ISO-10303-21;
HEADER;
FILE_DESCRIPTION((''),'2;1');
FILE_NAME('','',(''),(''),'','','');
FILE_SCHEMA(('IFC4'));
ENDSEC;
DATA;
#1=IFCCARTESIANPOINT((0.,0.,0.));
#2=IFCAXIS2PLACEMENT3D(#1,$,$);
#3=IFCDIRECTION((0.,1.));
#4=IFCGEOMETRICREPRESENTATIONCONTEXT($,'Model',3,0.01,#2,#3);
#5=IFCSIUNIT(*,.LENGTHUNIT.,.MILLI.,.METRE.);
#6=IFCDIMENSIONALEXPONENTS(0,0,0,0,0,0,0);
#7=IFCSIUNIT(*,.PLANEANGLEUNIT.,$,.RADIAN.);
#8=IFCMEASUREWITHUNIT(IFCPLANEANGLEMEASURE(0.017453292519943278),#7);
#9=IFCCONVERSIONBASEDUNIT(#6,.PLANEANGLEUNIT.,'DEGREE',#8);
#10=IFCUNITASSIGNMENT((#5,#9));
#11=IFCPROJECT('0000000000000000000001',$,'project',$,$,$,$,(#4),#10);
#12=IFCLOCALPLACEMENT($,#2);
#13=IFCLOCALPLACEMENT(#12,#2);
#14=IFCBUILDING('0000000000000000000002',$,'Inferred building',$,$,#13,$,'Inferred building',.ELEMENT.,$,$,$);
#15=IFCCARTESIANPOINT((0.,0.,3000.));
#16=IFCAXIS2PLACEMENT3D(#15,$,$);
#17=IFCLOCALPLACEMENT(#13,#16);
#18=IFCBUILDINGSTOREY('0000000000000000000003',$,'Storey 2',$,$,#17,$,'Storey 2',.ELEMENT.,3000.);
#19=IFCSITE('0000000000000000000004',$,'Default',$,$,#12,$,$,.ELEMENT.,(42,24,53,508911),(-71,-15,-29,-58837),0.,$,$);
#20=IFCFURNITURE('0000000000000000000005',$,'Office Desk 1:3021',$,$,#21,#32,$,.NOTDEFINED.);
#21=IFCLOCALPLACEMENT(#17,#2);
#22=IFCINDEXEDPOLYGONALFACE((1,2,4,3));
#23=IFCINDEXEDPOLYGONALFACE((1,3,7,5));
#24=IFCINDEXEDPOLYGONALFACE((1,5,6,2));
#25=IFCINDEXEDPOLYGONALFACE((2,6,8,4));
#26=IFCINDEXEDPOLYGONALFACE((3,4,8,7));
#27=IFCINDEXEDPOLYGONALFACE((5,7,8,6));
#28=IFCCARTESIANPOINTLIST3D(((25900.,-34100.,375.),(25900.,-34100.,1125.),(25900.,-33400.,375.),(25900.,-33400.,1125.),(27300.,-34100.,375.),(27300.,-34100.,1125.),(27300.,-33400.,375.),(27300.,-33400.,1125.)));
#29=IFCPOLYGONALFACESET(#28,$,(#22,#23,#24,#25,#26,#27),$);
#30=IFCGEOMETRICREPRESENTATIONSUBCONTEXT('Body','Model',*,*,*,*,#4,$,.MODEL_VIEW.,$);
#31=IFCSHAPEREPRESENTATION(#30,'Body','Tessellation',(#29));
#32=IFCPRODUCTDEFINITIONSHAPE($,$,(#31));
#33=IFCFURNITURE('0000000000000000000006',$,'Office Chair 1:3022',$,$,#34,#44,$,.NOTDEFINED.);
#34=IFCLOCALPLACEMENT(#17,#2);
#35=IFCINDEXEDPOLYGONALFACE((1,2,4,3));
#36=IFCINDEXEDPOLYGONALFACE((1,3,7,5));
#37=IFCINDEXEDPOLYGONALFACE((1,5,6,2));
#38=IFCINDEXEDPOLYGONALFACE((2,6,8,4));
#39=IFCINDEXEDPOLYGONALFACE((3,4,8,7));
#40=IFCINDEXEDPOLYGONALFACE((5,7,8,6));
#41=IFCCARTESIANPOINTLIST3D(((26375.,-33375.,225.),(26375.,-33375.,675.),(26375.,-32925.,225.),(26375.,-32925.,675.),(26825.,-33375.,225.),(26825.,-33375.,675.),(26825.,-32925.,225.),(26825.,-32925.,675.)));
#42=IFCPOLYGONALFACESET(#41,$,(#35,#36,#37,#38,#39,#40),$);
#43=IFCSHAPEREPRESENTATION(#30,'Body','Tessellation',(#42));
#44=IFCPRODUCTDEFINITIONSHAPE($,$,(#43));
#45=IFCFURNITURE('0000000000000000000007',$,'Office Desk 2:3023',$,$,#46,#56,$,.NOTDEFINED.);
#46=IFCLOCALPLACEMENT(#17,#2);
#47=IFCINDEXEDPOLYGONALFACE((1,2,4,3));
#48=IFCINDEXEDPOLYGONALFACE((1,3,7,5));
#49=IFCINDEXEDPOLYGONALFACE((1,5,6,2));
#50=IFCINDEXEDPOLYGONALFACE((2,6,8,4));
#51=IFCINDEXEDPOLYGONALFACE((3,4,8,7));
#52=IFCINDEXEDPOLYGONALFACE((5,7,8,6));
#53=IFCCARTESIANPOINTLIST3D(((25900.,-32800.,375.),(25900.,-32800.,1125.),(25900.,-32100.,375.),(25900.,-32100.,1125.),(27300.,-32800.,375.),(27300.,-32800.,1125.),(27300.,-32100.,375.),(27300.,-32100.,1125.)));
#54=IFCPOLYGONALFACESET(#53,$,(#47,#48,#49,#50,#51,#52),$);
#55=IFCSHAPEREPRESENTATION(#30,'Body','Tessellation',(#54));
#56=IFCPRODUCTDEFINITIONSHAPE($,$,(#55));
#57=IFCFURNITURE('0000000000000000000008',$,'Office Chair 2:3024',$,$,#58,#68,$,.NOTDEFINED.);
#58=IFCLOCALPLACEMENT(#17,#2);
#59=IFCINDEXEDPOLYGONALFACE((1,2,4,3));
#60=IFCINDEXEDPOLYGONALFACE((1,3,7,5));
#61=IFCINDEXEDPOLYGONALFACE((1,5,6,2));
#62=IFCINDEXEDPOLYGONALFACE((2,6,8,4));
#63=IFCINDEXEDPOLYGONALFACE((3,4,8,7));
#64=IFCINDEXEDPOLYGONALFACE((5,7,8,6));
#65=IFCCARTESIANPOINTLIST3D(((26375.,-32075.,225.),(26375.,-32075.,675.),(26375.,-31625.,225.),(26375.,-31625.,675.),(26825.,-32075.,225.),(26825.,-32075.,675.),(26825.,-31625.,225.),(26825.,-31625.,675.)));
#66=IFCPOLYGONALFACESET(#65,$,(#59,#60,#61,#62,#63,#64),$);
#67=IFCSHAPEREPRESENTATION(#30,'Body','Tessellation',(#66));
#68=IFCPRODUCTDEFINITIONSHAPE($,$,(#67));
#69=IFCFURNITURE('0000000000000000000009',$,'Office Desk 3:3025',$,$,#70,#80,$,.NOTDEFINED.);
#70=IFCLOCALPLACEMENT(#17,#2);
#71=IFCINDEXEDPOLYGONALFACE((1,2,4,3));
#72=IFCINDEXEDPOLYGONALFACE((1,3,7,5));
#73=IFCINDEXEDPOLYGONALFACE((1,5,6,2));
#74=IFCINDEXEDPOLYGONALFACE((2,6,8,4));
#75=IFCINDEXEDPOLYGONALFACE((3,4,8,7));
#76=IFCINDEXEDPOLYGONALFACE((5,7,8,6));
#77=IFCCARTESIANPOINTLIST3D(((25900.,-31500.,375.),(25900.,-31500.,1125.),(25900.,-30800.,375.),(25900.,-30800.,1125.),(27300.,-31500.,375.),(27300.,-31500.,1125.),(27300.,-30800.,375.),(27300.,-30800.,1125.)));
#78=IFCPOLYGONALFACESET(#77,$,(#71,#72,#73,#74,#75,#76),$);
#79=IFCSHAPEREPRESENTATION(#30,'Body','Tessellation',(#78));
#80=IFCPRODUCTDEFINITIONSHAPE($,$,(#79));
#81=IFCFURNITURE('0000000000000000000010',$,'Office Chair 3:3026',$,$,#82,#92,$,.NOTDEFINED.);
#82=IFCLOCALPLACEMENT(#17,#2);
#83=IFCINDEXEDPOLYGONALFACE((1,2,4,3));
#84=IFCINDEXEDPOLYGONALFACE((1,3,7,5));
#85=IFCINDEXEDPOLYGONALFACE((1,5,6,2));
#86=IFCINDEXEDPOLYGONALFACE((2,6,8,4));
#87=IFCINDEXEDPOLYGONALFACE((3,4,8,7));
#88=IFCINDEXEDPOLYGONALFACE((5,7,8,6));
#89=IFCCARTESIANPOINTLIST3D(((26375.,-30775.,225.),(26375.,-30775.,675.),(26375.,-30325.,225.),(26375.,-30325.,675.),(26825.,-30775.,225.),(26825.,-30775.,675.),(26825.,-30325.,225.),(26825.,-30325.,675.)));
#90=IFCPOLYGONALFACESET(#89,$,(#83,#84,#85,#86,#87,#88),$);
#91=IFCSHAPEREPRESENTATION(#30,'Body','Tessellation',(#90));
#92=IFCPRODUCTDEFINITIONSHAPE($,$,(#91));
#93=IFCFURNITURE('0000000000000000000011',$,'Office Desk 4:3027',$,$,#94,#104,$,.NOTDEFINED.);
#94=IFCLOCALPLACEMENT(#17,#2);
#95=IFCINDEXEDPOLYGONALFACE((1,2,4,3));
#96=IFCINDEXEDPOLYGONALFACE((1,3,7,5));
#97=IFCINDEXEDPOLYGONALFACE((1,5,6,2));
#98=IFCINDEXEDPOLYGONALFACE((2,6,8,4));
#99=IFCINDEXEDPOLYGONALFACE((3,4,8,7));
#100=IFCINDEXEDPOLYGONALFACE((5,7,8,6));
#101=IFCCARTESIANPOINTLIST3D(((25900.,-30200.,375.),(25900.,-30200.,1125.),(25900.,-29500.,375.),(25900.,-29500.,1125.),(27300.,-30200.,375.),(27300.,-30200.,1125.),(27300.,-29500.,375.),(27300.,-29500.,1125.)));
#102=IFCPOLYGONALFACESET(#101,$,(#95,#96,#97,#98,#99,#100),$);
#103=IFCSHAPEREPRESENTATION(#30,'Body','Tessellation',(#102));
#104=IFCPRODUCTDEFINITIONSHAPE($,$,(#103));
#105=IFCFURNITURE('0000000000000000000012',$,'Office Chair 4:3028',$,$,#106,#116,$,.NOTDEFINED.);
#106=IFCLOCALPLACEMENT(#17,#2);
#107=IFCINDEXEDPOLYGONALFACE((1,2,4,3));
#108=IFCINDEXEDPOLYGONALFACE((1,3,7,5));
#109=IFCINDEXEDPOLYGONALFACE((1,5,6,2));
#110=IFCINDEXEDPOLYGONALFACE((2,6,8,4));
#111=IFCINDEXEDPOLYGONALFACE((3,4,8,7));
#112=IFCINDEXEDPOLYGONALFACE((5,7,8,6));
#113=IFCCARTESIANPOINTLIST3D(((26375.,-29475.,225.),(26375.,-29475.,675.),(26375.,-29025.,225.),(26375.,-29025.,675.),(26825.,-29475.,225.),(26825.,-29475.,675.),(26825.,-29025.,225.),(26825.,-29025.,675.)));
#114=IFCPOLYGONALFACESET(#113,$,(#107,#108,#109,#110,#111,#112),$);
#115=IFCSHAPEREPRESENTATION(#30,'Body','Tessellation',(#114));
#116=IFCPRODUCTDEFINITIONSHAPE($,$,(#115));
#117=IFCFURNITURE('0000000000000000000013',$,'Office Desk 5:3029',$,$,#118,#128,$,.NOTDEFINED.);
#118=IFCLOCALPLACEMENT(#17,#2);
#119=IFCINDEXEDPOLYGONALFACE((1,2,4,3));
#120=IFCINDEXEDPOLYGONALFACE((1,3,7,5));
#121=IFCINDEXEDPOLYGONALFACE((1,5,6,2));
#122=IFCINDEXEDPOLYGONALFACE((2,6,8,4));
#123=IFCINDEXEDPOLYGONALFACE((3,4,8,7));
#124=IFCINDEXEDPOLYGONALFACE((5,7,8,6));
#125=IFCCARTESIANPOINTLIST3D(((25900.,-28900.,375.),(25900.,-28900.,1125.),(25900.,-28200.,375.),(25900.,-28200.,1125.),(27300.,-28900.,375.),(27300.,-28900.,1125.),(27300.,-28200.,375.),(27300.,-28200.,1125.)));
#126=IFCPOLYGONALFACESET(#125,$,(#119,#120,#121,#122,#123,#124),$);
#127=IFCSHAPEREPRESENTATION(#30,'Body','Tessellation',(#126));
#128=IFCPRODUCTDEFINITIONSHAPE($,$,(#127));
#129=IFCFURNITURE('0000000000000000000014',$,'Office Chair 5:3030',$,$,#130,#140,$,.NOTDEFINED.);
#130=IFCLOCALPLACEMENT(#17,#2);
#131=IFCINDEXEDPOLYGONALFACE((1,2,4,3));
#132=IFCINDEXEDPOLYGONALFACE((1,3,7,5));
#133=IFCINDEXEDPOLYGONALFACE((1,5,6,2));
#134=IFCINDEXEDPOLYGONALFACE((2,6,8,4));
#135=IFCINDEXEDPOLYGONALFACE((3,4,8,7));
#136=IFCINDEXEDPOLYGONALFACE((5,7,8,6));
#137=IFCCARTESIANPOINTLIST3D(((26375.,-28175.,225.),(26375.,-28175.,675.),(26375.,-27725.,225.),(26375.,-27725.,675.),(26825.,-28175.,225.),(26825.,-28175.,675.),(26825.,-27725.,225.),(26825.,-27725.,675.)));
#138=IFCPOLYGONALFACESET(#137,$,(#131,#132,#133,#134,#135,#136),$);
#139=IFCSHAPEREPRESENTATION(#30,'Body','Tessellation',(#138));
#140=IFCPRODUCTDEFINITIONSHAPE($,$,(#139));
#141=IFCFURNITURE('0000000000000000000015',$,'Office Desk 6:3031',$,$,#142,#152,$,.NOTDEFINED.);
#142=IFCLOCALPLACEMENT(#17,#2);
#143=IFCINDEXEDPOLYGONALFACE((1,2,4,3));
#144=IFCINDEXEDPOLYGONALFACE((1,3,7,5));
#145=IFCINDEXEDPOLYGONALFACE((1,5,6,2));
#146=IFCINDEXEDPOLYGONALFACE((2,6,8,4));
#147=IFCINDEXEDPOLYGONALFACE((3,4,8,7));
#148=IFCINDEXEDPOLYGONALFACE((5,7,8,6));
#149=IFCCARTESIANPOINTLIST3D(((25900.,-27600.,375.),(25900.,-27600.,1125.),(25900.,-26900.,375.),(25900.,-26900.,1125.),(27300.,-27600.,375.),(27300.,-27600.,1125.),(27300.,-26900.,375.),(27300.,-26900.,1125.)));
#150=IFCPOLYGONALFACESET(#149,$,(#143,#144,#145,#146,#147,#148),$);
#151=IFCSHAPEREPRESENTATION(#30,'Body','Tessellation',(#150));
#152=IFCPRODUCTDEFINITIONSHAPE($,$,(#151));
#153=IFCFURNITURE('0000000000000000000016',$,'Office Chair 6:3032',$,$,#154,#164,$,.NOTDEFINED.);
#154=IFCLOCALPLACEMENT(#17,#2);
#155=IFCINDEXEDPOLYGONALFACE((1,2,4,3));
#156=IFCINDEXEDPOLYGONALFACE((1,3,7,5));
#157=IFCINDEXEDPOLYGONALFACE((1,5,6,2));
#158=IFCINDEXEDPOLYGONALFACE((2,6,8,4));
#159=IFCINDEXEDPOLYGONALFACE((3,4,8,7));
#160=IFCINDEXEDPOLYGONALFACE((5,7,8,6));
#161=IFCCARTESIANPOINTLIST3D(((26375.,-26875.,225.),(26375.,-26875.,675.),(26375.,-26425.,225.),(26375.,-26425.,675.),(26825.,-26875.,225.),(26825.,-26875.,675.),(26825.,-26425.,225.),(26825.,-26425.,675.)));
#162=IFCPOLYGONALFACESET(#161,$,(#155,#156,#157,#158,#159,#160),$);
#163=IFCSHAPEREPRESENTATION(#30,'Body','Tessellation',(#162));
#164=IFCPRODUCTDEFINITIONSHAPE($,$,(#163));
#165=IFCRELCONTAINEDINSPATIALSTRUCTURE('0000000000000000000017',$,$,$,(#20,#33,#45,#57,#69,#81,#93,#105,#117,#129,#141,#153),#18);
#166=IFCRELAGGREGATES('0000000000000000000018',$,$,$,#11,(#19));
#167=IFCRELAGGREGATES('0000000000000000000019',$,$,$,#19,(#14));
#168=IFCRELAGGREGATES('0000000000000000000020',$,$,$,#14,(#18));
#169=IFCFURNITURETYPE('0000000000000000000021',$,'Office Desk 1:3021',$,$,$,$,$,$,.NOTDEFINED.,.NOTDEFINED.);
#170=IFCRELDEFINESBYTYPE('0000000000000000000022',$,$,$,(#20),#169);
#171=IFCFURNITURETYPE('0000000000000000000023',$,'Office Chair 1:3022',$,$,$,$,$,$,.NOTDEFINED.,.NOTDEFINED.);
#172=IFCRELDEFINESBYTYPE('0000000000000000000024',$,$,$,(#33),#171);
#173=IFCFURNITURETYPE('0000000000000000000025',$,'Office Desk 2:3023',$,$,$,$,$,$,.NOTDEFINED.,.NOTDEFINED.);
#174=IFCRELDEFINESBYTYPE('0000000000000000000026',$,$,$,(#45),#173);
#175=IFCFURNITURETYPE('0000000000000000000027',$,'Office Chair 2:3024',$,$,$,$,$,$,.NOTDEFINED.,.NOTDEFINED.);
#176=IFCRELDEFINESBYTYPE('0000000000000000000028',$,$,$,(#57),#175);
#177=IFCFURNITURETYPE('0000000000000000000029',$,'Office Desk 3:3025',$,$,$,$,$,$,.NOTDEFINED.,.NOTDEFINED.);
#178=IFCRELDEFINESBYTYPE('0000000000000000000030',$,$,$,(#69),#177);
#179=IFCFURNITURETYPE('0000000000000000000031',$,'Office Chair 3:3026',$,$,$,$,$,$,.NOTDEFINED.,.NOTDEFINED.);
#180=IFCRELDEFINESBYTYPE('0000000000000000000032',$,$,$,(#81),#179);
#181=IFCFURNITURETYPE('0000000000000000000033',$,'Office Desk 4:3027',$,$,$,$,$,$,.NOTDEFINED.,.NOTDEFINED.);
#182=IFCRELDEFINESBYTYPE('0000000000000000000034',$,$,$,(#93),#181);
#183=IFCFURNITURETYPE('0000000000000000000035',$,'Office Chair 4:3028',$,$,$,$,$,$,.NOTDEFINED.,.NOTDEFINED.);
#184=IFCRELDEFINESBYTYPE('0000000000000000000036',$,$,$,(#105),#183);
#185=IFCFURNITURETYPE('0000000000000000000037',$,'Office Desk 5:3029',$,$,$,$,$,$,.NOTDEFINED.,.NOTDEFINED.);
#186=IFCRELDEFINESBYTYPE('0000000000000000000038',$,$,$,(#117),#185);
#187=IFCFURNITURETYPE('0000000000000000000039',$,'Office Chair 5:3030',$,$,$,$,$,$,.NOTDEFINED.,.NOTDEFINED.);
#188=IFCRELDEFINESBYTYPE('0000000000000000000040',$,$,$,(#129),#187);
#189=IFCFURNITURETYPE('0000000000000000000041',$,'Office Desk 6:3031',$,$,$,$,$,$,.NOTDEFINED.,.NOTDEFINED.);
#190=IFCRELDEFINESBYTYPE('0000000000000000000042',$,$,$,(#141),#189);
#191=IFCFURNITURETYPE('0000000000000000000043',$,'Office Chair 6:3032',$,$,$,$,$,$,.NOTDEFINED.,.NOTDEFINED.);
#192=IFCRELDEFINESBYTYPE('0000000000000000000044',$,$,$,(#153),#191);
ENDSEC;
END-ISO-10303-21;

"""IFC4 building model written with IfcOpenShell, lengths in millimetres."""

from ifc_helpers import new_model, entity, si_unit, converted_unit, direction, frame, origin, origin_2d_with_axis, place, context, subcontext, project, spatial, rectangle, extrude, type_object, element, save


model = new_model("IFC4")

# Units and contexts
model_context = context("Model", 3, precision=0.01, world=origin(), true_north=direction((0.0, 1.0)))
body_context = subcontext(model_context, "Body", "Model", "MODEL_VIEW")
ifc_project = project(units=[si_unit("LENGTHUNIT", "METRE", prefix="MILLI"), converted_unit("PLANEANGLEUNIT", "DEGREE", entity("IfcPlaneAngleMeasure", 0.017453292519943278), si_unit("PLANEANGLEUNIT", "RADIAN"), dimensions=[0, 0, 0, 0, 0, 0, 0])], contexts=[model_context])

# Site, building, storey
site_placement = place(None, origin())
site = spatial("IfcSite", under=ifc_project, at=site_placement, Name="Default", CompositionType="ELEMENT", RefLatitude=(42, 24, 53, 508911), RefLongitude=(-71, -15, -29, -58837), RefElevation=0.0)
building_placement = place(site_placement, origin())
building = spatial("IfcBuilding", under=site, at=building_placement, Name="Inferred building", LongName="Inferred building", CompositionType="ELEMENT")
storey_placement = place(building_placement, frame((0.0, 0.0, 3000.0)))
storey = spatial("IfcBuildingStorey", under=building, at=storey_placement, Name="Storey 2", LongName="Storey 2", CompositionType="ELEMENT", Elevation=3000.0)

# Furniture
furniture_type_1 = type_object("IfcFurnitureType", Name="Office Desk 1:3021", PredefinedType="NOTDEFINED")
furniture_1_placement = place(storey_placement, origin())
element("IfcFurniture", 1, at=furniture_1_placement, inside=storey, type_object=furniture_type_1, Name="Office Desk 1:3021", PredefinedType="NOTDEFINED", context=body_context, shape_type="SweptSolid", body=[
    extrude(rectangle(XDim=1400.0, YDim=700.0, at=origin_2d_with_axis()), frame((26600.0, -33750.0, 375.0)), (0.0, 0.0, 1.0), 750.0),
])
furniture_type_2 = type_object("IfcFurnitureType", Name="Office Chair 1:3022", PredefinedType="NOTDEFINED")
furniture_2_placement = place(storey_placement, origin())
element("IfcFurniture", 2, at=furniture_2_placement, inside=storey, type_object=furniture_type_2, Name="Office Chair 1:3022", PredefinedType="NOTDEFINED", context=body_context, shape_type="SweptSolid", body=[
    extrude(rectangle(XDim=450.0, YDim=450.0, at=origin_2d_with_axis()), frame((26600.0, -33150.0, 225.0)), (0.0, 0.0, 1.0), 450.0),
])
furniture_type_3 = type_object("IfcFurnitureType", Name="Office Desk 2:3023", PredefinedType="NOTDEFINED")
furniture_3_placement = place(storey_placement, origin())
element("IfcFurniture", 3, at=furniture_3_placement, inside=storey, type_object=furniture_type_3, Name="Office Desk 2:3023", PredefinedType="NOTDEFINED", context=body_context, shape_type="SweptSolid", body=[
    extrude(rectangle(XDim=1400.0, YDim=700.0, at=origin_2d_with_axis()), frame((26600.0, -32450.0, 375.0)), (0.0, 0.0, 1.0), 750.0),
])
furniture_type_4 = type_object("IfcFurnitureType", Name="Office Chair 2:3024", PredefinedType="NOTDEFINED")
furniture_4_placement = place(storey_placement, origin())
element("IfcFurniture", 4, at=furniture_4_placement, inside=storey, type_object=furniture_type_4, Name="Office Chair 2:3024", PredefinedType="NOTDEFINED", context=body_context, shape_type="SweptSolid", body=[
    extrude(rectangle(XDim=450.0, YDim=450.0, at=origin_2d_with_axis()), frame((26600.0, -31850.0, 225.0)), (0.0, 0.0, 1.0), 450.0),
])
furniture_type_5 = type_object("IfcFurnitureType", Name="Office Desk 3:3025", PredefinedType="NOTDEFINED")
furniture_5_placement = place(storey_placement, origin())
element("IfcFurniture", 5, at=furniture_5_placement, inside=storey, type_object=furniture_type_5, Name="Office Desk 3:3025", PredefinedType="NOTDEFINED", context=body_context, shape_type="SweptSolid", body=[
    extrude(rectangle(XDim=1400.0, YDim=700.0, at=origin_2d_with_axis()), frame((26600.0, -31150.0, 375.0)), (0.0, 0.0, 1.0), 750.0),
])
furniture_type_6 = type_object("IfcFurnitureType", Name="Office Chair 3:3026", PredefinedType="NOTDEFINED")
furniture_6_placement = place(storey_placement, origin())
element("IfcFurniture", 6, at=furniture_6_placement, inside=storey, type_object=furniture_type_6, Name="Office Chair 3:3026", PredefinedType="NOTDEFINED", context=body_context, shape_type="SweptSolid", body=[
    extrude(rectangle(XDim=450.0, YDim=450.0, at=origin_2d_with_axis()), frame((26600.0, -30550.0, 225.0)), (0.0, 0.0, 1.0), 450.0),
])
furniture_type_7 = type_object("IfcFurnitureType", Name="Office Desk 4:3027", PredefinedType="NOTDEFINED")
furniture_7_placement = place(storey_placement, origin())
element("IfcFurniture", 7, at=furniture_7_placement, inside=storey, type_object=furniture_type_7, Name="Office Desk 4:3027", PredefinedType="NOTDEFINED", context=body_context, shape_type="SweptSolid", body=[
    extrude(rectangle(XDim=1400.0, YDim=700.0, at=origin_2d_with_axis()), frame((26600.0, -29850.0, 375.0)), (0.0, 0.0, 1.0), 750.0),
])
furniture_type_8 = type_object("IfcFurnitureType", Name="Office Chair 4:3028", PredefinedType="NOTDEFINED")
furniture_8_placement = place(storey_placement, origin())
element("IfcFurniture", 8, at=furniture_8_placement, inside=storey, type_object=furniture_type_8, Name="Office Chair 4:3028", PredefinedType="NOTDEFINED", context=body_context, shape_type="SweptSolid", body=[
    extrude(rectangle(XDim=450.0, YDim=450.0, at=origin_2d_with_axis()), frame((26600.0, -29250.0, 225.0)), (0.0, 0.0, 1.0), 450.0),
])
furniture_type_9 = type_object("IfcFurnitureType", Name="Office Desk 5:3029", PredefinedType="NOTDEFINED")
furniture_9_placement = place(storey_placement, origin())
element("IfcFurniture", 9, at=furniture_9_placement, inside=storey, type_object=furniture_type_9, Name="Office Desk 5:3029", PredefinedType="NOTDEFINED", context=body_context, shape_type="SweptSolid", body=[
    extrude(rectangle(XDim=1400.0, YDim=700.0, at=origin_2d_with_axis()), frame((26600.0, -28550.0, 375.0)), (0.0, 0.0, 1.0), 750.0),
])
furniture_type_10 = type_object("IfcFurnitureType", Name="Office Chair 5:3030", PredefinedType="NOTDEFINED")
furniture_10_placement = place(storey_placement, origin())
element("IfcFurniture", 10, at=furniture_10_placement, inside=storey, type_object=furniture_type_10, Name="Office Chair 5:3030", PredefinedType="NOTDEFINED", context=body_context, shape_type="SweptSolid", body=[
    extrude(rectangle(XDim=450.0, YDim=450.0, at=origin_2d_with_axis()), frame((26600.0, -27950.0, 225.0)), (0.0, 0.0, 1.0), 450.0),
])
furniture_type_11 = type_object("IfcFurnitureType", Name="Office Desk 6:3031", PredefinedType="NOTDEFINED")
furniture_11_placement = place(storey_placement, origin())
element("IfcFurniture", 11, at=furniture_11_placement, inside=storey, type_object=furniture_type_11, Name="Office Desk 6:3031", PredefinedType="NOTDEFINED", context=body_context, shape_type="SweptSolid", body=[
    extrude(rectangle(XDim=1400.0, YDim=700.0, at=origin_2d_with_axis()), frame((26600.0, -27250.0, 375.0)), (0.0, 0.0, 1.0), 750.0),
])
furniture_type_12 = type_object("IfcFurnitureType", Name="Office Chair 6:3032", PredefinedType="NOTDEFINED")
furniture_12_placement = place(storey_placement, origin())
element("IfcFurniture", 12, at=furniture_12_placement, inside=storey, type_object=furniture_type_12, Name="Office Chair 6:3032", PredefinedType="NOTDEFINED", context=body_context, shape_type="SweptSolid", body=[
    extrude(rectangle(XDim=450.0, YDim=450.0, at=origin_2d_with_axis()), frame((26600.0, -26650.0, 225.0)), (0.0, 0.0, 1.0), 450.0),
])

save(model, "model.ifc")
